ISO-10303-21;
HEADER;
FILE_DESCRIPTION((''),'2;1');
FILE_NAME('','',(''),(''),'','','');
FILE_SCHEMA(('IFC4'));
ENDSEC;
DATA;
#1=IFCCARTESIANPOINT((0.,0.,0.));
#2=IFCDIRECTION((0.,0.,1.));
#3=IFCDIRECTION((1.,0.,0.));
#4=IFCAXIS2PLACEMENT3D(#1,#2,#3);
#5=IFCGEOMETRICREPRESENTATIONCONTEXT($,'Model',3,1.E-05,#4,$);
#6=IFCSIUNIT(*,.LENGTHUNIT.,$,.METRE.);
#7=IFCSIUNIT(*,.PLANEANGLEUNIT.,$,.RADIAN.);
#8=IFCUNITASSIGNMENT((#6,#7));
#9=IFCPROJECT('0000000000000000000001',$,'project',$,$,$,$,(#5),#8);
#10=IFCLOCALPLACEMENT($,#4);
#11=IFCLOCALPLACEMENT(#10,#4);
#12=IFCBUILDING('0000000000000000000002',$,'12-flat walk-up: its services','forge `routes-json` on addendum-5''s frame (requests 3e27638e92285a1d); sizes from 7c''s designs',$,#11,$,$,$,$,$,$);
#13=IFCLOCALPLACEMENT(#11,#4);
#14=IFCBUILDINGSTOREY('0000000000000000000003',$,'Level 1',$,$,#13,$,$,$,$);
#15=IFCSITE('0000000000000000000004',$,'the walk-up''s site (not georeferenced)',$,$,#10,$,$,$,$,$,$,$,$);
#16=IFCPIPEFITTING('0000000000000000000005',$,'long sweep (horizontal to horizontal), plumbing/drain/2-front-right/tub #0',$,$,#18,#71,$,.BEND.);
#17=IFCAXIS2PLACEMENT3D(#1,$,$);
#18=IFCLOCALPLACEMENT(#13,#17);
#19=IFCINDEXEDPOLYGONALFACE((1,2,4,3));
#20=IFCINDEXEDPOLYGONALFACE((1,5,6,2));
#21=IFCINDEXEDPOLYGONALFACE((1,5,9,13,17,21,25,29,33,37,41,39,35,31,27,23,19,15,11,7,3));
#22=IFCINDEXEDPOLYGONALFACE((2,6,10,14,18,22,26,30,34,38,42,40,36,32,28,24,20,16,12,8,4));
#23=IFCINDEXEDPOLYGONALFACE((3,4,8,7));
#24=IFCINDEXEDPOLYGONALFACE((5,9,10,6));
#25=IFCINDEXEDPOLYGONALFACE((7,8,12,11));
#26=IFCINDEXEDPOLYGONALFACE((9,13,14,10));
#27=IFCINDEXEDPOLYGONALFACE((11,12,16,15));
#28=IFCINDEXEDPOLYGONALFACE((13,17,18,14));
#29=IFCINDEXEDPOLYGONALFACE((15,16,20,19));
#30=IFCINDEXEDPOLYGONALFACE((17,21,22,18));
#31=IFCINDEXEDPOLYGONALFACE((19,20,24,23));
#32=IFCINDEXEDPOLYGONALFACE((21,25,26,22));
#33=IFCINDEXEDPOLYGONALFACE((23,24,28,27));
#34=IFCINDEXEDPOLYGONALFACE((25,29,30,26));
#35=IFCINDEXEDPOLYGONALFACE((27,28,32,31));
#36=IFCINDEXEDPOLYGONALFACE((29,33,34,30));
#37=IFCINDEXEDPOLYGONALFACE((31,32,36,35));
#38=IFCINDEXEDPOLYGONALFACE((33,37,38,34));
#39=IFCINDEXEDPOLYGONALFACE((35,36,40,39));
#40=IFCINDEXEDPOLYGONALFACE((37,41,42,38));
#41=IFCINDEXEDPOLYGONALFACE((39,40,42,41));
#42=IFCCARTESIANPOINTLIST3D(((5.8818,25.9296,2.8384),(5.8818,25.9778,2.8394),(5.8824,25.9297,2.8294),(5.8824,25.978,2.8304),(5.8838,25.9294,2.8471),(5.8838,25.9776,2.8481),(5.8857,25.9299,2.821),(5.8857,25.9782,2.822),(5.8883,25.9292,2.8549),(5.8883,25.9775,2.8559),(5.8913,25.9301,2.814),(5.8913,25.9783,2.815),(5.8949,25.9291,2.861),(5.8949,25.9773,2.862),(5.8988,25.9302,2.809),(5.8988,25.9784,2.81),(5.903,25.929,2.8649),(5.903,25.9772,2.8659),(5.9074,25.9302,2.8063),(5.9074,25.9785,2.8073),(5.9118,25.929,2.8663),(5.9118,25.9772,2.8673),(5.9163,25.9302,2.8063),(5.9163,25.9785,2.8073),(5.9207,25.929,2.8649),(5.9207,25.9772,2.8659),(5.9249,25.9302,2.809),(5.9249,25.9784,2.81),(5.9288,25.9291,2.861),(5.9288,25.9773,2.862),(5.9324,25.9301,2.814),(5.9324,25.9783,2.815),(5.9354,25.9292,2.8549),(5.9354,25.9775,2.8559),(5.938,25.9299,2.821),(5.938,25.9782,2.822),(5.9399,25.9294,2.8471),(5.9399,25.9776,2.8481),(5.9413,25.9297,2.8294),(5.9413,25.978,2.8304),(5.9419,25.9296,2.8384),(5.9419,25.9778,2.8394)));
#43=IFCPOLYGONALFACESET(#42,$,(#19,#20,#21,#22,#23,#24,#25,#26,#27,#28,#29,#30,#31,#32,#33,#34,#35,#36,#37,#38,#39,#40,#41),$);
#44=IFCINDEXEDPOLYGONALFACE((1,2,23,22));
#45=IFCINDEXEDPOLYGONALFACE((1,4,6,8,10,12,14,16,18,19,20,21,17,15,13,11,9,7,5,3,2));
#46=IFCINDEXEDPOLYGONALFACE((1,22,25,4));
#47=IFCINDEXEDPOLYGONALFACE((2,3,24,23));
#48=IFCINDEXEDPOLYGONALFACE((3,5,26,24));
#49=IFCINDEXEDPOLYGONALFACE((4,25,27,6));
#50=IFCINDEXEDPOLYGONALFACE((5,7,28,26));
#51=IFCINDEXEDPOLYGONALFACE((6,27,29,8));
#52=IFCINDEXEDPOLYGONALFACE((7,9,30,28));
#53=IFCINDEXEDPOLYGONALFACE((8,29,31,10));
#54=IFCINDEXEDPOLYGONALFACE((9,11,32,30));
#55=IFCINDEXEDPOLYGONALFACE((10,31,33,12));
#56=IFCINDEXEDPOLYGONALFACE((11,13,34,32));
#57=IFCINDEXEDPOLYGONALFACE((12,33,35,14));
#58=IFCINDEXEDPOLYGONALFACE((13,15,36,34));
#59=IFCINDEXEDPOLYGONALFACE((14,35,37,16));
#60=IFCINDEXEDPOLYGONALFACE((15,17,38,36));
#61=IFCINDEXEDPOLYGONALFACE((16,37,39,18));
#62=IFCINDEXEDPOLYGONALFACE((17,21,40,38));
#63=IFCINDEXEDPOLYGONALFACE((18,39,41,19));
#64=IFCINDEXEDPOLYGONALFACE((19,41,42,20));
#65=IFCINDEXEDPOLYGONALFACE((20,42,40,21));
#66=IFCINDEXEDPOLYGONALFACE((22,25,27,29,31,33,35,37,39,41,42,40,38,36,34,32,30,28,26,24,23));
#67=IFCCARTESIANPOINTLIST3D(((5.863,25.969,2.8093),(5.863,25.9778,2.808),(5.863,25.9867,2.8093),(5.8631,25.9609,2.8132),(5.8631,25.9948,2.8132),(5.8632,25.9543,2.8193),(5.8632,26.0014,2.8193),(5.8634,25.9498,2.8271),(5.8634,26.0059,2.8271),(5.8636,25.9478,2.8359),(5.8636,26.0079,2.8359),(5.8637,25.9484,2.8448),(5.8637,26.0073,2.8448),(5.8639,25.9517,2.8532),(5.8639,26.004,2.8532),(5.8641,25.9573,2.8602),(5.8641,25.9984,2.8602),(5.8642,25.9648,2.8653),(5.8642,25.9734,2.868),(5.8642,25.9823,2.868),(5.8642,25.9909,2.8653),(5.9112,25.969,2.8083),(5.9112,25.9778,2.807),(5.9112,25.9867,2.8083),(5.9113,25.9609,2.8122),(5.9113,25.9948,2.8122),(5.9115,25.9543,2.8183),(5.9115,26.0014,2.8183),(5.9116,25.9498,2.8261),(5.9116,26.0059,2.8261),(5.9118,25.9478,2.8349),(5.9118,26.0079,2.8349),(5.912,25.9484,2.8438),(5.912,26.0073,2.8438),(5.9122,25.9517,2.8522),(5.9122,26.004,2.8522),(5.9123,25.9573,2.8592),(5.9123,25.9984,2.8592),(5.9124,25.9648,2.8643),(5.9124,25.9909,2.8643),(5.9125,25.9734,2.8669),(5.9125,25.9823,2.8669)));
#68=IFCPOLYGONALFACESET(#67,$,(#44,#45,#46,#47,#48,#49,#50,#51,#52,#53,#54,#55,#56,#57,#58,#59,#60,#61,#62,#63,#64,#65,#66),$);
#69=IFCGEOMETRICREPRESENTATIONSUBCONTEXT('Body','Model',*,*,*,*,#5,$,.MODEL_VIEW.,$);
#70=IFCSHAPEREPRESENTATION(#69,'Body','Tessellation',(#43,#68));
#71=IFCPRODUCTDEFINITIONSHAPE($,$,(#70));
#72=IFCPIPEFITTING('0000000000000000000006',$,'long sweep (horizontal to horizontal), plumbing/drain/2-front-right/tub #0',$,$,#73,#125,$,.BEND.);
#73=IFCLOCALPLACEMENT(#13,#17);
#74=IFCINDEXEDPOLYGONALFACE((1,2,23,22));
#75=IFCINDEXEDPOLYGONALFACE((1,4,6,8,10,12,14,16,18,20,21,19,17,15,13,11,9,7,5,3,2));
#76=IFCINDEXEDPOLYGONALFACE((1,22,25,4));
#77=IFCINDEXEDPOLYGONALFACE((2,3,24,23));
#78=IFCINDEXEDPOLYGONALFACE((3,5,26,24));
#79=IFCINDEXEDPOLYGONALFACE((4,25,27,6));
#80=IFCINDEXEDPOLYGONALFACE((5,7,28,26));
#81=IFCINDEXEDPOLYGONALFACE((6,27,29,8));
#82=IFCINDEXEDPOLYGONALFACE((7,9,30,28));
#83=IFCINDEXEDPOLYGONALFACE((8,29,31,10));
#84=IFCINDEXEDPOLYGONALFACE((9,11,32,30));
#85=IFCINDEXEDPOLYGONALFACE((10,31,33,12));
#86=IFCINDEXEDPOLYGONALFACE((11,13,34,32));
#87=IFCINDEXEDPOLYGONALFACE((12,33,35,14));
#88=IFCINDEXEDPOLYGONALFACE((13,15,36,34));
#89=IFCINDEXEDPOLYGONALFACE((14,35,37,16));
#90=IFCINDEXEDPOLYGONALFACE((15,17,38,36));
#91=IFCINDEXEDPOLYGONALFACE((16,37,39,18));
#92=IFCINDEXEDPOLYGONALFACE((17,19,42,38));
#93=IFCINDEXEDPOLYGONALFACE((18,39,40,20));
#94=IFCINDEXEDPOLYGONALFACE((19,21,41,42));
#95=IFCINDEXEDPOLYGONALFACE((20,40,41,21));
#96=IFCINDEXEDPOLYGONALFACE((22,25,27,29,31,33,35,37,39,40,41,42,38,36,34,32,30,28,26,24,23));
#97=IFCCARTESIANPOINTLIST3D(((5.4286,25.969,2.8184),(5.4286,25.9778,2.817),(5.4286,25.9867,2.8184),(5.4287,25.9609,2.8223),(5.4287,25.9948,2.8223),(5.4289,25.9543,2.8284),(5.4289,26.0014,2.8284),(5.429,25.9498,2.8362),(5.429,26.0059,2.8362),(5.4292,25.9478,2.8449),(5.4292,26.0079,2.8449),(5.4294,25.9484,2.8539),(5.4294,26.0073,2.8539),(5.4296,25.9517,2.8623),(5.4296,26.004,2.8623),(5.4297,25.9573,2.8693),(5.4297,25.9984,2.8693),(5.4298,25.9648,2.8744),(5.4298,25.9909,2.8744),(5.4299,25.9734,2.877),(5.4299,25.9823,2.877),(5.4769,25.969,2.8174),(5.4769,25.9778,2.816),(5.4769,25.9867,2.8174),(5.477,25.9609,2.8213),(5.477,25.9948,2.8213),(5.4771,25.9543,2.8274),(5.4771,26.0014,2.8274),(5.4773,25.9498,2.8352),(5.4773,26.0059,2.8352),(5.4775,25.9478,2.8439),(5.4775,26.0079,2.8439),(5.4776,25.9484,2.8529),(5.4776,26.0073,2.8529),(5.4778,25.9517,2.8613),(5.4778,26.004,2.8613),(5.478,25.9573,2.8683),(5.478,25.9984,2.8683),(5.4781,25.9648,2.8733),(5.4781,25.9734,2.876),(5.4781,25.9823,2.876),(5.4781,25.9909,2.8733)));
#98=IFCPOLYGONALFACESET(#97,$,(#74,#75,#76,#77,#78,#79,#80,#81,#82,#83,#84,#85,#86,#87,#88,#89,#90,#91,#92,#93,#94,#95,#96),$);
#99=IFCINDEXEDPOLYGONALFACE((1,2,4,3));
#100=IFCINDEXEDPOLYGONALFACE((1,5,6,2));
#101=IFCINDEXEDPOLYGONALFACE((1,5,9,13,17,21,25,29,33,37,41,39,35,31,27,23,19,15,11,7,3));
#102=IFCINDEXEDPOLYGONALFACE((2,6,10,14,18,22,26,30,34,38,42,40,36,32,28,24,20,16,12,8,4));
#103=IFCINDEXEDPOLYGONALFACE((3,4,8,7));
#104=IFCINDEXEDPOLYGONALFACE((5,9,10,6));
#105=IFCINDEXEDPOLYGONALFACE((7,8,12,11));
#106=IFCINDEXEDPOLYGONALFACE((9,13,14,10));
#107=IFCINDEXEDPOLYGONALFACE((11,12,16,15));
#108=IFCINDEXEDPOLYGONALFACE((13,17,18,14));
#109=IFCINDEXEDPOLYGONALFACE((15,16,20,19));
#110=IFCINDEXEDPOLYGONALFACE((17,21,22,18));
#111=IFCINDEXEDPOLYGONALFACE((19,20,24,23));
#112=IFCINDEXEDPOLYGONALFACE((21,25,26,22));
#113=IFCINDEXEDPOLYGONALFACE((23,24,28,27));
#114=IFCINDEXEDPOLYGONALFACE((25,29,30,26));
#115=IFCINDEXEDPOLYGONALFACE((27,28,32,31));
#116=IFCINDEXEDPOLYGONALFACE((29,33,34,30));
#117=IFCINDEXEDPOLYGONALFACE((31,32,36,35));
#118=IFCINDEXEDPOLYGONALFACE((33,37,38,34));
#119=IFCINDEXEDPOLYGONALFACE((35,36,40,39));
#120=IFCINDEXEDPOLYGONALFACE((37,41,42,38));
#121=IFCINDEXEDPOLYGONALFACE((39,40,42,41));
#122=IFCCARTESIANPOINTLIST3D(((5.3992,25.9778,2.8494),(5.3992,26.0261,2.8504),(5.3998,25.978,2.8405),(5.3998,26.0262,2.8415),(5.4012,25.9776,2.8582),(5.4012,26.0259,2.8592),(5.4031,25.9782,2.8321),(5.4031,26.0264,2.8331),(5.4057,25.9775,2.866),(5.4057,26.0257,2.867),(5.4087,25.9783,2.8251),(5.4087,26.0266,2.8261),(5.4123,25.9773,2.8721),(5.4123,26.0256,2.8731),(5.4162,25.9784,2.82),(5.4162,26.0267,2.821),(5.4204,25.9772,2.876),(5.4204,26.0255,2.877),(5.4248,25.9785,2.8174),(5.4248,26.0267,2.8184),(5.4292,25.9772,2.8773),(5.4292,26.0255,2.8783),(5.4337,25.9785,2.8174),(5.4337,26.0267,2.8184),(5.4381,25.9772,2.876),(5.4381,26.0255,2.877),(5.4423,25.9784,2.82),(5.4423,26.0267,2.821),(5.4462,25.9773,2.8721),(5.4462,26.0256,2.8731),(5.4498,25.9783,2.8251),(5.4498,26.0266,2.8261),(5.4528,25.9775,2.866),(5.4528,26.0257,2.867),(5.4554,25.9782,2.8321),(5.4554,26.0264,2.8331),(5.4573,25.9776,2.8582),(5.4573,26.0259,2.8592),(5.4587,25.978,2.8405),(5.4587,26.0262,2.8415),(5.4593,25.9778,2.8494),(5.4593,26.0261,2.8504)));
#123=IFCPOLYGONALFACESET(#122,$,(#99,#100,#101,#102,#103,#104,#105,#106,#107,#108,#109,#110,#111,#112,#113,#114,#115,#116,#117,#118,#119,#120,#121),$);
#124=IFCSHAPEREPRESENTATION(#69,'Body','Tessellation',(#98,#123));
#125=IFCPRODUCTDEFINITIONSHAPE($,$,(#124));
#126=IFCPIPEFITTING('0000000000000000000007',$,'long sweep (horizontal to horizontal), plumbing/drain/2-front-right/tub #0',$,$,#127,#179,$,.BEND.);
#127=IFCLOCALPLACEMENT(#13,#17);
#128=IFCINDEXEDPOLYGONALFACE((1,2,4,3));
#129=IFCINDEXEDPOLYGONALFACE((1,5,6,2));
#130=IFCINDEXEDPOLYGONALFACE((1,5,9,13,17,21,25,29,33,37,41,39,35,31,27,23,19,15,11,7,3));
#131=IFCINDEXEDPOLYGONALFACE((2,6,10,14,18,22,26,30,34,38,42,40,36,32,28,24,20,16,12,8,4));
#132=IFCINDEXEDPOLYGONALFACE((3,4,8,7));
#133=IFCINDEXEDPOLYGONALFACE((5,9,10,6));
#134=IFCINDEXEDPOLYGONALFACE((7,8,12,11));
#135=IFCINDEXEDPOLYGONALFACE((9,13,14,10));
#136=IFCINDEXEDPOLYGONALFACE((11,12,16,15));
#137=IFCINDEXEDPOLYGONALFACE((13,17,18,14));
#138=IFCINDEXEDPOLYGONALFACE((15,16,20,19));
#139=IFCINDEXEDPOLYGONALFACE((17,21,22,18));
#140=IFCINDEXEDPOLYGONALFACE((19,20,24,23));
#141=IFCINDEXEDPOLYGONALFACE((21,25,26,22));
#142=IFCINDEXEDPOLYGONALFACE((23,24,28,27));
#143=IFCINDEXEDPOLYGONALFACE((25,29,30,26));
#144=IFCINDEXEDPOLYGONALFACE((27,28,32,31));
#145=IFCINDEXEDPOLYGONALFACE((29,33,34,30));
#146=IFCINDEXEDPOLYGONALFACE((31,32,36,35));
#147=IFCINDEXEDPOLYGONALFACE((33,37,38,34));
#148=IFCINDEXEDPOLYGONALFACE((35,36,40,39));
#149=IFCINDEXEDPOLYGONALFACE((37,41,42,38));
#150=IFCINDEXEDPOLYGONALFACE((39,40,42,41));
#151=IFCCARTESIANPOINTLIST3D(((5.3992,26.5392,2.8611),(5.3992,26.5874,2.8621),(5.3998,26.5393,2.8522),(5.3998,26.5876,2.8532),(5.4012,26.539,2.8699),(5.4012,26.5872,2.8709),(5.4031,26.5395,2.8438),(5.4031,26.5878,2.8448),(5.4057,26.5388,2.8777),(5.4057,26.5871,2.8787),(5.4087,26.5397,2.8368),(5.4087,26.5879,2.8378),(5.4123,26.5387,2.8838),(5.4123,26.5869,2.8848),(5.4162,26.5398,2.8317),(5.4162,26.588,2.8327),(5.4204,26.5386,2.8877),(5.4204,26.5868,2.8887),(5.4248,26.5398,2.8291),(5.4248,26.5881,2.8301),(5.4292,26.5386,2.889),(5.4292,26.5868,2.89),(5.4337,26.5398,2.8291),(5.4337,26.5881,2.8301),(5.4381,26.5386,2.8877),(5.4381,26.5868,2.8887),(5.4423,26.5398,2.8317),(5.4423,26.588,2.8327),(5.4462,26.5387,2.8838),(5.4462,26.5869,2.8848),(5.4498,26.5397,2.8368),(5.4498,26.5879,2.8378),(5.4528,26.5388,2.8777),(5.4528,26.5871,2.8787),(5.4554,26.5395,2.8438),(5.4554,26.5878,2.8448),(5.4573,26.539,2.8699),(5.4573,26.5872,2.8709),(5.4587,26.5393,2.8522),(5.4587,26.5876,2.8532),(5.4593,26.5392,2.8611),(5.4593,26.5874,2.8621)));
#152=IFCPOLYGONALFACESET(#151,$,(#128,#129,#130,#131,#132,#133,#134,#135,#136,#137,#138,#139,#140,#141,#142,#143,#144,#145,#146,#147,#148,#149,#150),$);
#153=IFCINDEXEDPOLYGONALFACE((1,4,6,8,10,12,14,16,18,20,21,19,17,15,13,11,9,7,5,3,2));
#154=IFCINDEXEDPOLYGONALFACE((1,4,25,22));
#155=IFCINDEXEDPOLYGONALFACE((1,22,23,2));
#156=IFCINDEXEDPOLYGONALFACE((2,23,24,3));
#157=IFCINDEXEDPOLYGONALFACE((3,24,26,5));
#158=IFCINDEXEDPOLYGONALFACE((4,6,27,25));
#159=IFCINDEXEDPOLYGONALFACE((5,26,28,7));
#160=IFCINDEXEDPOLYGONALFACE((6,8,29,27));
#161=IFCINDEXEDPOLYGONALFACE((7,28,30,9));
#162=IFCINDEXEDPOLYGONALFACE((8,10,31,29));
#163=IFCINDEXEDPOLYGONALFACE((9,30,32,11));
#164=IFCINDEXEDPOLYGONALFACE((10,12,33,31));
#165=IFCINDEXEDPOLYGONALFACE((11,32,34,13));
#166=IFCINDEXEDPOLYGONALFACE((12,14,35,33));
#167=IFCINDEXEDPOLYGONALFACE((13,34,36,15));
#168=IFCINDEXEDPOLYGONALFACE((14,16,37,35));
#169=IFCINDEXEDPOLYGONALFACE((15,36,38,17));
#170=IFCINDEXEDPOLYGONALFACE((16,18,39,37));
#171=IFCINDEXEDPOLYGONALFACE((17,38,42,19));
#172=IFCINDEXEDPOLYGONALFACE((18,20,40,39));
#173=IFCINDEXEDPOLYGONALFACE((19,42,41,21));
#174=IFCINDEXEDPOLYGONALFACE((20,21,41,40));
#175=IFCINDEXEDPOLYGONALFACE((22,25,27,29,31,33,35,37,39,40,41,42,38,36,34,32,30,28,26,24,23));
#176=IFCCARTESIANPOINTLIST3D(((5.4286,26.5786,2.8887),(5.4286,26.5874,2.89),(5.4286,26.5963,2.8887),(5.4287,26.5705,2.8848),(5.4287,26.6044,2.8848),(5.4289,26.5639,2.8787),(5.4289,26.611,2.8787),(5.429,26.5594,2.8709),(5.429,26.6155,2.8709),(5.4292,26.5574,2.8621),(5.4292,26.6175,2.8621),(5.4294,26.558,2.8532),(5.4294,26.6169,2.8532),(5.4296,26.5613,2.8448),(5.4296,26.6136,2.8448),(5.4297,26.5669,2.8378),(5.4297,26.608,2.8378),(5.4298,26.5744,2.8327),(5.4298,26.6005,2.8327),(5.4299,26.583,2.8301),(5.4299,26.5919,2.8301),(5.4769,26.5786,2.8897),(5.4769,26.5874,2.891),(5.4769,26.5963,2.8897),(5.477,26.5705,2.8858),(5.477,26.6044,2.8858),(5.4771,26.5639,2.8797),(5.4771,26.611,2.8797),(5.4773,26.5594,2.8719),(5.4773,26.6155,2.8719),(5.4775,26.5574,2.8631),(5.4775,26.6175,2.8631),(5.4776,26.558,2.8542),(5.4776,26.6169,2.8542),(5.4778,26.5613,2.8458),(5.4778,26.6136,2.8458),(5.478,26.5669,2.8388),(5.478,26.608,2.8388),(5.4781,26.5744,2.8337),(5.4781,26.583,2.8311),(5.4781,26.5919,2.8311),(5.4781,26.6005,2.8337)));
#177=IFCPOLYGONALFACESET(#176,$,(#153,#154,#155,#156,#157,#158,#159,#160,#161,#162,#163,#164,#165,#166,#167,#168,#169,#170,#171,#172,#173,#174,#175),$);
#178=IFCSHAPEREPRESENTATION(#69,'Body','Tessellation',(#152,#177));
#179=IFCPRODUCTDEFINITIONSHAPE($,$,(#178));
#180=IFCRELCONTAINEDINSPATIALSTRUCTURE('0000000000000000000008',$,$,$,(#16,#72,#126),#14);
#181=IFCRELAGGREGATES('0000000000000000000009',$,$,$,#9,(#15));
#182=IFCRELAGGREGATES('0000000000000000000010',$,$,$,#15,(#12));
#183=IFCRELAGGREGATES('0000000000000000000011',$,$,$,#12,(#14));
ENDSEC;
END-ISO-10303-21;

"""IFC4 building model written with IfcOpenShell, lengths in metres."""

from ifc_helpers import new_model, entity, si_unit, frame, origin_with_axes, place, context, subcontext, project, spatial, element, save


model = new_model("IFC4")

# Units and contexts
model_context = context("Model", 3, precision=1e-05, world=origin_with_axes())
body_context = subcontext(model_context, "Body", "Model", "MODEL_VIEW")
ifc_project = project(units=[si_unit("LENGTHUNIT", "METRE"), si_unit("PLANEANGLEUNIT", "RADIAN")], contexts=[model_context])

# Site, building, storey
site_placement = place(None, origin_with_axes())
site = spatial("IfcSite", under=ifc_project, at=site_placement, Name="the walk-up's site (not georeferenced)")
building_placement = place(site_placement, origin_with_axes())
building = spatial("IfcBuilding", under=site, at=building_placement, Name="12-flat walk-up: its services", Description="forge `routes-json` on addendum-5's frame (requests 3e27638e92285a1d); sizes from 7c's designs")
storey_placement = place(building_placement, origin_with_axes())
storey = spatial("IfcBuildingStorey", under=building, at=storey_placement, Name="Level 1")

# Pipe fittings
pipe_fitting_1_placement = place(storey_placement, frame((5.9118, 25.9296, 2.8361), z_axis=(0.0, 0.0, 1.0), x_axis=(1.0, 0.0, 0.0)))
element("IfcPipeFitting", 1, at=pipe_fitting_1_placement, inside=storey, Name="long sweep (horizontal to horizontal), plumbing/drain/2-front-right/tub #0", PredefinedType="BEND", context=body_context, shape_type="AdvancedSweptSolid", body=[
    entity("IfcSweptDiskSolid", entity("IfcPolyline", [entity("IfcCartesianPoint", [0.0, 0.0, 0.0]), entity("IfcCartesianPoint", [0.0, 0.0482, 0.001])]), 0.0302),
    entity("IfcSweptDiskSolid", entity("IfcPolyline", [entity("IfcCartesianPoint", [0.0, 0.0482, 0.001]), entity("IfcCartesianPoint", [-0.0482, 0.0482, 0.002])]), 0.0302),
])
pipe_fitting_2_placement = place(storey_placement, frame((5.4775, 25.9779, 2.8462), z_axis=(0.0, 0.0, 1.0), x_axis=(1.0, 0.0, 0.0)))
element("IfcPipeFitting", 2, at=pipe_fitting_2_placement, inside=storey, Name="long sweep (horizontal to horizontal), plumbing/drain/2-front-right/tub #0", PredefinedType="BEND", context=body_context, shape_type="AdvancedSweptSolid", body=[
    entity("IfcSweptDiskSolid", entity("IfcPolyline", [entity("IfcCartesianPoint", [0.0, 0.0, 0.0]), entity("IfcCartesianPoint", [-0.0482, 0.0, 0.001])]), 0.0302),
    entity("IfcSweptDiskSolid", entity("IfcPolyline", [entity("IfcCartesianPoint", [-0.0482, 0.0, 0.001]), entity("IfcCartesianPoint", [-0.0482, 0.0482, 0.002])]), 0.0302),
])
pipe_fitting_3_placement = place(storey_placement, frame((5.4292, 26.5392, 2.8589), z_axis=(0.0, 0.0, 1.0), x_axis=(1.0, 0.0, 0.0)))
element("IfcPipeFitting", 3, at=pipe_fitting_3_placement, inside=storey, Name="long sweep (horizontal to horizontal), plumbing/drain/2-front-right/tub #0", PredefinedType="BEND", context=body_context, shape_type="AdvancedSweptSolid", body=[
    entity("IfcSweptDiskSolid", entity("IfcPolyline", [entity("IfcCartesianPoint", [0.0, 0.0, 0.0]), entity("IfcCartesianPoint", [0.0, 0.0482, 0.001])]), 0.0302),
    entity("IfcSweptDiskSolid", entity("IfcPolyline", [entity("IfcCartesianPoint", [0.0, 0.0482, 0.001]), entity("IfcCartesianPoint", [0.0482, 0.0482, 0.002])]), 0.0302),
])

save(model, "model.ifc")
